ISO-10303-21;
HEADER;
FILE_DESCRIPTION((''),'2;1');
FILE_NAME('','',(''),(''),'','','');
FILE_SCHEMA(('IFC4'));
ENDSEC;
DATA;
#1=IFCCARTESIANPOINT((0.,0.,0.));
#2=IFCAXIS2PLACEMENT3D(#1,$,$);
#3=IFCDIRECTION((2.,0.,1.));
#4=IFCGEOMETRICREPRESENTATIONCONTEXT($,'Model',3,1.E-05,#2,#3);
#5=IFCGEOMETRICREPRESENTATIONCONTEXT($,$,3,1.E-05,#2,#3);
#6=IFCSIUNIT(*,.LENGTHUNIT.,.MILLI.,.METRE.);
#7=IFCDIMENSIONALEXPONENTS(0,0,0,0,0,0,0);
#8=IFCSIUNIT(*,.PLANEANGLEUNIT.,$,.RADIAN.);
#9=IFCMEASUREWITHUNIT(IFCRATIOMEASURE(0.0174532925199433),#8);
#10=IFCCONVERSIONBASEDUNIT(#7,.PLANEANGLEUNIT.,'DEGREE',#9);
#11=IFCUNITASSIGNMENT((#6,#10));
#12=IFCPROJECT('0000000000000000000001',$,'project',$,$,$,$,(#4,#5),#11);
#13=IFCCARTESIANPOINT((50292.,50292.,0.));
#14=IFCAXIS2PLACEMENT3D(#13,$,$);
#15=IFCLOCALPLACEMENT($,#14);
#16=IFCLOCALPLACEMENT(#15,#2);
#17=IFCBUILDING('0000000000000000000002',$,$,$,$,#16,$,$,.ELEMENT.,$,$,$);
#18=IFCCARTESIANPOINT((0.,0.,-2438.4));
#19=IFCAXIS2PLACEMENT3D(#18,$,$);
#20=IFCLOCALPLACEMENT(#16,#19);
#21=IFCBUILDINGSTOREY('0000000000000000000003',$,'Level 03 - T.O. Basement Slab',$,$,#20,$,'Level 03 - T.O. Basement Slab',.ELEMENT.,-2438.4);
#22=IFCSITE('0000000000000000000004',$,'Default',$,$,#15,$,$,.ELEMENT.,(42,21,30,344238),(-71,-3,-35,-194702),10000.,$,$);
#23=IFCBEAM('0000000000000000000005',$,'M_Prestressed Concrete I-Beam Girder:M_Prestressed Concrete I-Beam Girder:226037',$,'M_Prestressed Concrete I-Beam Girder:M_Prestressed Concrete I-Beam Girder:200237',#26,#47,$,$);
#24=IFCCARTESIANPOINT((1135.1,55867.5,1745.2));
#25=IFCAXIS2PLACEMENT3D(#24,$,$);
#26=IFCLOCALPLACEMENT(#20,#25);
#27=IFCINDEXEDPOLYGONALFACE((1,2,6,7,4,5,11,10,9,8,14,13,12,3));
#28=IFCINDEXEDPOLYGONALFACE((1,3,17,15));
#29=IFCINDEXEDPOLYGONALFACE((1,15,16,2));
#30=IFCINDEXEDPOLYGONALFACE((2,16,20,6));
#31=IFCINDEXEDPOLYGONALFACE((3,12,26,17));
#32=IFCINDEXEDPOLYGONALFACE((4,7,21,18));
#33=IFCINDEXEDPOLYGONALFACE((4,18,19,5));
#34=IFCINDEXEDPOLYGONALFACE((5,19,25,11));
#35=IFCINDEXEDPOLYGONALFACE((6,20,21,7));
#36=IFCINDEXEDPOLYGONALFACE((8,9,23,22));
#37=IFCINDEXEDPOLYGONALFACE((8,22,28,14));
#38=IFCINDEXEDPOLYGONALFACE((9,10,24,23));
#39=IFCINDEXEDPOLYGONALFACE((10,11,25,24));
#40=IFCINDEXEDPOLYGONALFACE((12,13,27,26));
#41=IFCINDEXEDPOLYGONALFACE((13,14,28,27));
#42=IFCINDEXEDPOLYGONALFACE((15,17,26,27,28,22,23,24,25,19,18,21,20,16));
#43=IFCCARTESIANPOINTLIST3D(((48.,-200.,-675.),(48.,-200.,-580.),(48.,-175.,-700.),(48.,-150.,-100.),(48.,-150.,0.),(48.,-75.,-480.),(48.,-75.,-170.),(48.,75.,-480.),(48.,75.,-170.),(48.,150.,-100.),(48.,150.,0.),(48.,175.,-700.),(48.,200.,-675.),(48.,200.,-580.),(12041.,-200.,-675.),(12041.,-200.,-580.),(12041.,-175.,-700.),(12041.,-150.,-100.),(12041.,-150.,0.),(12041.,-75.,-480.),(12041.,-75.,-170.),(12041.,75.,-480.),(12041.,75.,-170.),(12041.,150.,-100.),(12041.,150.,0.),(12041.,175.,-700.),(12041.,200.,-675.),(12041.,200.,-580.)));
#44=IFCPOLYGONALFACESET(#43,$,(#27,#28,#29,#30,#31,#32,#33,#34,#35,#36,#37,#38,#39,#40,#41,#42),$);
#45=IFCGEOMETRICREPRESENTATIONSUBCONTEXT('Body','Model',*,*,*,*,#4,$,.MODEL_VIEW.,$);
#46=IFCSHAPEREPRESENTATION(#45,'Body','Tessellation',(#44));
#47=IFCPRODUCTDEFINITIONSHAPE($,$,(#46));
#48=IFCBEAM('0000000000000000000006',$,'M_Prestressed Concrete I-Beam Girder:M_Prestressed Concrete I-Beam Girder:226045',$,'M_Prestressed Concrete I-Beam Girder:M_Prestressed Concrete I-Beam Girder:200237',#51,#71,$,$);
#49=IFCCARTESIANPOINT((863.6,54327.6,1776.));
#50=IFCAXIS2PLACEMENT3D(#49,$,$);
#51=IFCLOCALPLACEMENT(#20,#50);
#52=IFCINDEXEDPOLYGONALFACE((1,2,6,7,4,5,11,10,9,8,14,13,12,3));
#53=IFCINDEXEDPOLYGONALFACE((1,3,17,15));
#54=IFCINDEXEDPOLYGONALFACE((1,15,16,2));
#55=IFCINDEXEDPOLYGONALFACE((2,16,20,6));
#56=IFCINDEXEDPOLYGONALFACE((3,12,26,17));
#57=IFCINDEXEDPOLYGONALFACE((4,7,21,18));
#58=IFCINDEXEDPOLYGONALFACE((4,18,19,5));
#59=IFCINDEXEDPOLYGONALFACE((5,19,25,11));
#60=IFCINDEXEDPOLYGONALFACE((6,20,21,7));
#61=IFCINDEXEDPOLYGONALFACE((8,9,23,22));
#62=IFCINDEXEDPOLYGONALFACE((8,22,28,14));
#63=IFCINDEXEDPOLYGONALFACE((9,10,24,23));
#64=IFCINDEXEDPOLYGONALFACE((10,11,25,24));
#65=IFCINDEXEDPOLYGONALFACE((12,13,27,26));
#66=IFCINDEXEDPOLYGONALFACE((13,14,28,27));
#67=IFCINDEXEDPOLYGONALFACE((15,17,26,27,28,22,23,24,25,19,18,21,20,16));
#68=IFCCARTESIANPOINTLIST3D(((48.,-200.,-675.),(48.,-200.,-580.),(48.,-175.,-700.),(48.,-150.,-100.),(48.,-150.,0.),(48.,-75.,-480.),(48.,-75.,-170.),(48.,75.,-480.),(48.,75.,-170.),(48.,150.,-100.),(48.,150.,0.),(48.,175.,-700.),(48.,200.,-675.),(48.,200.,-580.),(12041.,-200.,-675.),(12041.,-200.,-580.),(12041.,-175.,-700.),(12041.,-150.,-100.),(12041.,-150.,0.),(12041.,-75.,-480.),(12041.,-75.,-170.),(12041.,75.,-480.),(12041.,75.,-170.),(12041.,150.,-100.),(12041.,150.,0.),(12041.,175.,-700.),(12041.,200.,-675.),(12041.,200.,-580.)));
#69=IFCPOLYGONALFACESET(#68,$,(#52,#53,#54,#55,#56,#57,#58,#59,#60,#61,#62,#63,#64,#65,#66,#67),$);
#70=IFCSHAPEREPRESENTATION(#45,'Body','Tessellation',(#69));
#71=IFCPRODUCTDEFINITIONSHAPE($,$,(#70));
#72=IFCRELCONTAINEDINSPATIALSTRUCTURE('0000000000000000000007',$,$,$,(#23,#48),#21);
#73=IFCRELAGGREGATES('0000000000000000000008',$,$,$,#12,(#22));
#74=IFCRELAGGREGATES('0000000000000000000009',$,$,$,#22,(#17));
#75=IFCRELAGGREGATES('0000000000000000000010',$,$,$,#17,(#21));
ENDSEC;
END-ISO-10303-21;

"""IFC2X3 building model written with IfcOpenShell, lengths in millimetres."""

from ifc_helpers import new_model, entity, si_unit, converted_unit, direction, frame, origin, place, context, subcontext, project, spatial, polyline, outline, extrude, element, save


model = new_model("IFC2X3")

# Units and contexts
model_context = context("Model", 3, precision=1e-05, world=origin(), true_north=direction((2.0, 0.0, 1.0)))
context_of_model = context(None, 3, precision=1e-05, world=origin(), true_north=direction((2.0, 0.0, 1.0)))
body_context = subcontext(model_context, "Body", "Model", "MODEL_VIEW")
ifc_project = project(units=[si_unit("LENGTHUNIT", "METRE", prefix="MILLI"), converted_unit("PLANEANGLEUNIT", "DEGREE", entity("IfcRatioMeasure", 0.0174532925199433), si_unit("PLANEANGLEUNIT", "RADIAN"), dimensions=[0, 0, 0, 0, 0, 0, 0])], contexts=[model_context, context_of_model])

# Site, building, storey
site_placement = place(None, frame((50292.0, 50292.0, 0.0)))
site = spatial("IfcSite", under=ifc_project, at=site_placement, Name="Default", CompositionType="ELEMENT", RefLatitude=(42, 21, 30, 344238), RefLongitude=(-71, -3, -35, -194702), RefElevation=10000.0)
building_placement = place(site_placement, origin())
building = spatial("IfcBuilding", under=site, at=building_placement, CompositionType="ELEMENT")
storey_placement = place(building_placement, frame((0.0, 0.0, -2438.4)))
storey = spatial("IfcBuildingStorey", under=building, at=storey_placement, Name="Level 03 - T.O. Basement Slab", LongName="Level 03 - T.O. Basement Slab", CompositionType="ELEMENT", Elevation=-2438.4)

# Beams
beam_1_placement = place(storey_placement, frame((1135.1, 55867.5, 1745.2)))
element("IfcBeam", 1, at=beam_1_placement, inside=storey, Name="M_Prestressed Concrete I-Beam Girder:M_Prestressed Concrete I-Beam Girder:226037", ObjectType="M_Prestressed Concrete I-Beam Girder:M_Prestressed Concrete I-Beam Girder:200237", context=body_context, shape_type="SweptSolid", body=[
    extrude(outline(polyline([(193.6, -200.0), (288.6, -200.0), (313.6, -175.0), (313.6, 175.0), (288.6, 200.0), (193.6, 200.0), (93.6, 75.0), (-216.4, 75.0), (-286.4, 150.0), (-386.4, 150.0), (-386.4, -150.0), (-286.4, -150.0), (-216.4, -75.0), (93.6, -75.0), (193.6, -200.0)])), frame((48.0, 0.0, -386.4), z_axis=(1.0, 0.0, 0.0), x_axis=(0.0, 0.0, -1.0)), (0.0, 0.0, 1.0), 11993.0),
])
beam_2_placement = place(storey_placement, frame((863.6, 54327.6, 1776.0)))
element("IfcBeam", 2, at=beam_2_placement, inside=storey, Name="M_Prestressed Concrete I-Beam Girder:M_Prestressed Concrete I-Beam Girder:226045", ObjectType="M_Prestressed Concrete I-Beam Girder:M_Prestressed Concrete I-Beam Girder:200237", context=body_context, shape_type="SweptSolid", body=[
    extrude(outline(polyline([(193.6, -200.0), (288.6, -200.0), (313.6, -175.0), (313.6, 175.0), (288.6, 200.0), (193.6, 200.0), (93.6, 75.0), (-216.4, 75.0), (-286.4, 150.0), (-386.4, 150.0), (-386.4, -150.0), (-286.4, -150.0), (-216.4, -75.0), (93.6, -75.0), (193.6, -200.0)])), frame((48.0, 0.0, -386.4), z_axis=(1.0, 0.0, 0.0), x_axis=(0.0, 0.0, -1.0)), (0.0, 0.0, 1.0), 11993.0),
])

save(model, "model.ifc")
